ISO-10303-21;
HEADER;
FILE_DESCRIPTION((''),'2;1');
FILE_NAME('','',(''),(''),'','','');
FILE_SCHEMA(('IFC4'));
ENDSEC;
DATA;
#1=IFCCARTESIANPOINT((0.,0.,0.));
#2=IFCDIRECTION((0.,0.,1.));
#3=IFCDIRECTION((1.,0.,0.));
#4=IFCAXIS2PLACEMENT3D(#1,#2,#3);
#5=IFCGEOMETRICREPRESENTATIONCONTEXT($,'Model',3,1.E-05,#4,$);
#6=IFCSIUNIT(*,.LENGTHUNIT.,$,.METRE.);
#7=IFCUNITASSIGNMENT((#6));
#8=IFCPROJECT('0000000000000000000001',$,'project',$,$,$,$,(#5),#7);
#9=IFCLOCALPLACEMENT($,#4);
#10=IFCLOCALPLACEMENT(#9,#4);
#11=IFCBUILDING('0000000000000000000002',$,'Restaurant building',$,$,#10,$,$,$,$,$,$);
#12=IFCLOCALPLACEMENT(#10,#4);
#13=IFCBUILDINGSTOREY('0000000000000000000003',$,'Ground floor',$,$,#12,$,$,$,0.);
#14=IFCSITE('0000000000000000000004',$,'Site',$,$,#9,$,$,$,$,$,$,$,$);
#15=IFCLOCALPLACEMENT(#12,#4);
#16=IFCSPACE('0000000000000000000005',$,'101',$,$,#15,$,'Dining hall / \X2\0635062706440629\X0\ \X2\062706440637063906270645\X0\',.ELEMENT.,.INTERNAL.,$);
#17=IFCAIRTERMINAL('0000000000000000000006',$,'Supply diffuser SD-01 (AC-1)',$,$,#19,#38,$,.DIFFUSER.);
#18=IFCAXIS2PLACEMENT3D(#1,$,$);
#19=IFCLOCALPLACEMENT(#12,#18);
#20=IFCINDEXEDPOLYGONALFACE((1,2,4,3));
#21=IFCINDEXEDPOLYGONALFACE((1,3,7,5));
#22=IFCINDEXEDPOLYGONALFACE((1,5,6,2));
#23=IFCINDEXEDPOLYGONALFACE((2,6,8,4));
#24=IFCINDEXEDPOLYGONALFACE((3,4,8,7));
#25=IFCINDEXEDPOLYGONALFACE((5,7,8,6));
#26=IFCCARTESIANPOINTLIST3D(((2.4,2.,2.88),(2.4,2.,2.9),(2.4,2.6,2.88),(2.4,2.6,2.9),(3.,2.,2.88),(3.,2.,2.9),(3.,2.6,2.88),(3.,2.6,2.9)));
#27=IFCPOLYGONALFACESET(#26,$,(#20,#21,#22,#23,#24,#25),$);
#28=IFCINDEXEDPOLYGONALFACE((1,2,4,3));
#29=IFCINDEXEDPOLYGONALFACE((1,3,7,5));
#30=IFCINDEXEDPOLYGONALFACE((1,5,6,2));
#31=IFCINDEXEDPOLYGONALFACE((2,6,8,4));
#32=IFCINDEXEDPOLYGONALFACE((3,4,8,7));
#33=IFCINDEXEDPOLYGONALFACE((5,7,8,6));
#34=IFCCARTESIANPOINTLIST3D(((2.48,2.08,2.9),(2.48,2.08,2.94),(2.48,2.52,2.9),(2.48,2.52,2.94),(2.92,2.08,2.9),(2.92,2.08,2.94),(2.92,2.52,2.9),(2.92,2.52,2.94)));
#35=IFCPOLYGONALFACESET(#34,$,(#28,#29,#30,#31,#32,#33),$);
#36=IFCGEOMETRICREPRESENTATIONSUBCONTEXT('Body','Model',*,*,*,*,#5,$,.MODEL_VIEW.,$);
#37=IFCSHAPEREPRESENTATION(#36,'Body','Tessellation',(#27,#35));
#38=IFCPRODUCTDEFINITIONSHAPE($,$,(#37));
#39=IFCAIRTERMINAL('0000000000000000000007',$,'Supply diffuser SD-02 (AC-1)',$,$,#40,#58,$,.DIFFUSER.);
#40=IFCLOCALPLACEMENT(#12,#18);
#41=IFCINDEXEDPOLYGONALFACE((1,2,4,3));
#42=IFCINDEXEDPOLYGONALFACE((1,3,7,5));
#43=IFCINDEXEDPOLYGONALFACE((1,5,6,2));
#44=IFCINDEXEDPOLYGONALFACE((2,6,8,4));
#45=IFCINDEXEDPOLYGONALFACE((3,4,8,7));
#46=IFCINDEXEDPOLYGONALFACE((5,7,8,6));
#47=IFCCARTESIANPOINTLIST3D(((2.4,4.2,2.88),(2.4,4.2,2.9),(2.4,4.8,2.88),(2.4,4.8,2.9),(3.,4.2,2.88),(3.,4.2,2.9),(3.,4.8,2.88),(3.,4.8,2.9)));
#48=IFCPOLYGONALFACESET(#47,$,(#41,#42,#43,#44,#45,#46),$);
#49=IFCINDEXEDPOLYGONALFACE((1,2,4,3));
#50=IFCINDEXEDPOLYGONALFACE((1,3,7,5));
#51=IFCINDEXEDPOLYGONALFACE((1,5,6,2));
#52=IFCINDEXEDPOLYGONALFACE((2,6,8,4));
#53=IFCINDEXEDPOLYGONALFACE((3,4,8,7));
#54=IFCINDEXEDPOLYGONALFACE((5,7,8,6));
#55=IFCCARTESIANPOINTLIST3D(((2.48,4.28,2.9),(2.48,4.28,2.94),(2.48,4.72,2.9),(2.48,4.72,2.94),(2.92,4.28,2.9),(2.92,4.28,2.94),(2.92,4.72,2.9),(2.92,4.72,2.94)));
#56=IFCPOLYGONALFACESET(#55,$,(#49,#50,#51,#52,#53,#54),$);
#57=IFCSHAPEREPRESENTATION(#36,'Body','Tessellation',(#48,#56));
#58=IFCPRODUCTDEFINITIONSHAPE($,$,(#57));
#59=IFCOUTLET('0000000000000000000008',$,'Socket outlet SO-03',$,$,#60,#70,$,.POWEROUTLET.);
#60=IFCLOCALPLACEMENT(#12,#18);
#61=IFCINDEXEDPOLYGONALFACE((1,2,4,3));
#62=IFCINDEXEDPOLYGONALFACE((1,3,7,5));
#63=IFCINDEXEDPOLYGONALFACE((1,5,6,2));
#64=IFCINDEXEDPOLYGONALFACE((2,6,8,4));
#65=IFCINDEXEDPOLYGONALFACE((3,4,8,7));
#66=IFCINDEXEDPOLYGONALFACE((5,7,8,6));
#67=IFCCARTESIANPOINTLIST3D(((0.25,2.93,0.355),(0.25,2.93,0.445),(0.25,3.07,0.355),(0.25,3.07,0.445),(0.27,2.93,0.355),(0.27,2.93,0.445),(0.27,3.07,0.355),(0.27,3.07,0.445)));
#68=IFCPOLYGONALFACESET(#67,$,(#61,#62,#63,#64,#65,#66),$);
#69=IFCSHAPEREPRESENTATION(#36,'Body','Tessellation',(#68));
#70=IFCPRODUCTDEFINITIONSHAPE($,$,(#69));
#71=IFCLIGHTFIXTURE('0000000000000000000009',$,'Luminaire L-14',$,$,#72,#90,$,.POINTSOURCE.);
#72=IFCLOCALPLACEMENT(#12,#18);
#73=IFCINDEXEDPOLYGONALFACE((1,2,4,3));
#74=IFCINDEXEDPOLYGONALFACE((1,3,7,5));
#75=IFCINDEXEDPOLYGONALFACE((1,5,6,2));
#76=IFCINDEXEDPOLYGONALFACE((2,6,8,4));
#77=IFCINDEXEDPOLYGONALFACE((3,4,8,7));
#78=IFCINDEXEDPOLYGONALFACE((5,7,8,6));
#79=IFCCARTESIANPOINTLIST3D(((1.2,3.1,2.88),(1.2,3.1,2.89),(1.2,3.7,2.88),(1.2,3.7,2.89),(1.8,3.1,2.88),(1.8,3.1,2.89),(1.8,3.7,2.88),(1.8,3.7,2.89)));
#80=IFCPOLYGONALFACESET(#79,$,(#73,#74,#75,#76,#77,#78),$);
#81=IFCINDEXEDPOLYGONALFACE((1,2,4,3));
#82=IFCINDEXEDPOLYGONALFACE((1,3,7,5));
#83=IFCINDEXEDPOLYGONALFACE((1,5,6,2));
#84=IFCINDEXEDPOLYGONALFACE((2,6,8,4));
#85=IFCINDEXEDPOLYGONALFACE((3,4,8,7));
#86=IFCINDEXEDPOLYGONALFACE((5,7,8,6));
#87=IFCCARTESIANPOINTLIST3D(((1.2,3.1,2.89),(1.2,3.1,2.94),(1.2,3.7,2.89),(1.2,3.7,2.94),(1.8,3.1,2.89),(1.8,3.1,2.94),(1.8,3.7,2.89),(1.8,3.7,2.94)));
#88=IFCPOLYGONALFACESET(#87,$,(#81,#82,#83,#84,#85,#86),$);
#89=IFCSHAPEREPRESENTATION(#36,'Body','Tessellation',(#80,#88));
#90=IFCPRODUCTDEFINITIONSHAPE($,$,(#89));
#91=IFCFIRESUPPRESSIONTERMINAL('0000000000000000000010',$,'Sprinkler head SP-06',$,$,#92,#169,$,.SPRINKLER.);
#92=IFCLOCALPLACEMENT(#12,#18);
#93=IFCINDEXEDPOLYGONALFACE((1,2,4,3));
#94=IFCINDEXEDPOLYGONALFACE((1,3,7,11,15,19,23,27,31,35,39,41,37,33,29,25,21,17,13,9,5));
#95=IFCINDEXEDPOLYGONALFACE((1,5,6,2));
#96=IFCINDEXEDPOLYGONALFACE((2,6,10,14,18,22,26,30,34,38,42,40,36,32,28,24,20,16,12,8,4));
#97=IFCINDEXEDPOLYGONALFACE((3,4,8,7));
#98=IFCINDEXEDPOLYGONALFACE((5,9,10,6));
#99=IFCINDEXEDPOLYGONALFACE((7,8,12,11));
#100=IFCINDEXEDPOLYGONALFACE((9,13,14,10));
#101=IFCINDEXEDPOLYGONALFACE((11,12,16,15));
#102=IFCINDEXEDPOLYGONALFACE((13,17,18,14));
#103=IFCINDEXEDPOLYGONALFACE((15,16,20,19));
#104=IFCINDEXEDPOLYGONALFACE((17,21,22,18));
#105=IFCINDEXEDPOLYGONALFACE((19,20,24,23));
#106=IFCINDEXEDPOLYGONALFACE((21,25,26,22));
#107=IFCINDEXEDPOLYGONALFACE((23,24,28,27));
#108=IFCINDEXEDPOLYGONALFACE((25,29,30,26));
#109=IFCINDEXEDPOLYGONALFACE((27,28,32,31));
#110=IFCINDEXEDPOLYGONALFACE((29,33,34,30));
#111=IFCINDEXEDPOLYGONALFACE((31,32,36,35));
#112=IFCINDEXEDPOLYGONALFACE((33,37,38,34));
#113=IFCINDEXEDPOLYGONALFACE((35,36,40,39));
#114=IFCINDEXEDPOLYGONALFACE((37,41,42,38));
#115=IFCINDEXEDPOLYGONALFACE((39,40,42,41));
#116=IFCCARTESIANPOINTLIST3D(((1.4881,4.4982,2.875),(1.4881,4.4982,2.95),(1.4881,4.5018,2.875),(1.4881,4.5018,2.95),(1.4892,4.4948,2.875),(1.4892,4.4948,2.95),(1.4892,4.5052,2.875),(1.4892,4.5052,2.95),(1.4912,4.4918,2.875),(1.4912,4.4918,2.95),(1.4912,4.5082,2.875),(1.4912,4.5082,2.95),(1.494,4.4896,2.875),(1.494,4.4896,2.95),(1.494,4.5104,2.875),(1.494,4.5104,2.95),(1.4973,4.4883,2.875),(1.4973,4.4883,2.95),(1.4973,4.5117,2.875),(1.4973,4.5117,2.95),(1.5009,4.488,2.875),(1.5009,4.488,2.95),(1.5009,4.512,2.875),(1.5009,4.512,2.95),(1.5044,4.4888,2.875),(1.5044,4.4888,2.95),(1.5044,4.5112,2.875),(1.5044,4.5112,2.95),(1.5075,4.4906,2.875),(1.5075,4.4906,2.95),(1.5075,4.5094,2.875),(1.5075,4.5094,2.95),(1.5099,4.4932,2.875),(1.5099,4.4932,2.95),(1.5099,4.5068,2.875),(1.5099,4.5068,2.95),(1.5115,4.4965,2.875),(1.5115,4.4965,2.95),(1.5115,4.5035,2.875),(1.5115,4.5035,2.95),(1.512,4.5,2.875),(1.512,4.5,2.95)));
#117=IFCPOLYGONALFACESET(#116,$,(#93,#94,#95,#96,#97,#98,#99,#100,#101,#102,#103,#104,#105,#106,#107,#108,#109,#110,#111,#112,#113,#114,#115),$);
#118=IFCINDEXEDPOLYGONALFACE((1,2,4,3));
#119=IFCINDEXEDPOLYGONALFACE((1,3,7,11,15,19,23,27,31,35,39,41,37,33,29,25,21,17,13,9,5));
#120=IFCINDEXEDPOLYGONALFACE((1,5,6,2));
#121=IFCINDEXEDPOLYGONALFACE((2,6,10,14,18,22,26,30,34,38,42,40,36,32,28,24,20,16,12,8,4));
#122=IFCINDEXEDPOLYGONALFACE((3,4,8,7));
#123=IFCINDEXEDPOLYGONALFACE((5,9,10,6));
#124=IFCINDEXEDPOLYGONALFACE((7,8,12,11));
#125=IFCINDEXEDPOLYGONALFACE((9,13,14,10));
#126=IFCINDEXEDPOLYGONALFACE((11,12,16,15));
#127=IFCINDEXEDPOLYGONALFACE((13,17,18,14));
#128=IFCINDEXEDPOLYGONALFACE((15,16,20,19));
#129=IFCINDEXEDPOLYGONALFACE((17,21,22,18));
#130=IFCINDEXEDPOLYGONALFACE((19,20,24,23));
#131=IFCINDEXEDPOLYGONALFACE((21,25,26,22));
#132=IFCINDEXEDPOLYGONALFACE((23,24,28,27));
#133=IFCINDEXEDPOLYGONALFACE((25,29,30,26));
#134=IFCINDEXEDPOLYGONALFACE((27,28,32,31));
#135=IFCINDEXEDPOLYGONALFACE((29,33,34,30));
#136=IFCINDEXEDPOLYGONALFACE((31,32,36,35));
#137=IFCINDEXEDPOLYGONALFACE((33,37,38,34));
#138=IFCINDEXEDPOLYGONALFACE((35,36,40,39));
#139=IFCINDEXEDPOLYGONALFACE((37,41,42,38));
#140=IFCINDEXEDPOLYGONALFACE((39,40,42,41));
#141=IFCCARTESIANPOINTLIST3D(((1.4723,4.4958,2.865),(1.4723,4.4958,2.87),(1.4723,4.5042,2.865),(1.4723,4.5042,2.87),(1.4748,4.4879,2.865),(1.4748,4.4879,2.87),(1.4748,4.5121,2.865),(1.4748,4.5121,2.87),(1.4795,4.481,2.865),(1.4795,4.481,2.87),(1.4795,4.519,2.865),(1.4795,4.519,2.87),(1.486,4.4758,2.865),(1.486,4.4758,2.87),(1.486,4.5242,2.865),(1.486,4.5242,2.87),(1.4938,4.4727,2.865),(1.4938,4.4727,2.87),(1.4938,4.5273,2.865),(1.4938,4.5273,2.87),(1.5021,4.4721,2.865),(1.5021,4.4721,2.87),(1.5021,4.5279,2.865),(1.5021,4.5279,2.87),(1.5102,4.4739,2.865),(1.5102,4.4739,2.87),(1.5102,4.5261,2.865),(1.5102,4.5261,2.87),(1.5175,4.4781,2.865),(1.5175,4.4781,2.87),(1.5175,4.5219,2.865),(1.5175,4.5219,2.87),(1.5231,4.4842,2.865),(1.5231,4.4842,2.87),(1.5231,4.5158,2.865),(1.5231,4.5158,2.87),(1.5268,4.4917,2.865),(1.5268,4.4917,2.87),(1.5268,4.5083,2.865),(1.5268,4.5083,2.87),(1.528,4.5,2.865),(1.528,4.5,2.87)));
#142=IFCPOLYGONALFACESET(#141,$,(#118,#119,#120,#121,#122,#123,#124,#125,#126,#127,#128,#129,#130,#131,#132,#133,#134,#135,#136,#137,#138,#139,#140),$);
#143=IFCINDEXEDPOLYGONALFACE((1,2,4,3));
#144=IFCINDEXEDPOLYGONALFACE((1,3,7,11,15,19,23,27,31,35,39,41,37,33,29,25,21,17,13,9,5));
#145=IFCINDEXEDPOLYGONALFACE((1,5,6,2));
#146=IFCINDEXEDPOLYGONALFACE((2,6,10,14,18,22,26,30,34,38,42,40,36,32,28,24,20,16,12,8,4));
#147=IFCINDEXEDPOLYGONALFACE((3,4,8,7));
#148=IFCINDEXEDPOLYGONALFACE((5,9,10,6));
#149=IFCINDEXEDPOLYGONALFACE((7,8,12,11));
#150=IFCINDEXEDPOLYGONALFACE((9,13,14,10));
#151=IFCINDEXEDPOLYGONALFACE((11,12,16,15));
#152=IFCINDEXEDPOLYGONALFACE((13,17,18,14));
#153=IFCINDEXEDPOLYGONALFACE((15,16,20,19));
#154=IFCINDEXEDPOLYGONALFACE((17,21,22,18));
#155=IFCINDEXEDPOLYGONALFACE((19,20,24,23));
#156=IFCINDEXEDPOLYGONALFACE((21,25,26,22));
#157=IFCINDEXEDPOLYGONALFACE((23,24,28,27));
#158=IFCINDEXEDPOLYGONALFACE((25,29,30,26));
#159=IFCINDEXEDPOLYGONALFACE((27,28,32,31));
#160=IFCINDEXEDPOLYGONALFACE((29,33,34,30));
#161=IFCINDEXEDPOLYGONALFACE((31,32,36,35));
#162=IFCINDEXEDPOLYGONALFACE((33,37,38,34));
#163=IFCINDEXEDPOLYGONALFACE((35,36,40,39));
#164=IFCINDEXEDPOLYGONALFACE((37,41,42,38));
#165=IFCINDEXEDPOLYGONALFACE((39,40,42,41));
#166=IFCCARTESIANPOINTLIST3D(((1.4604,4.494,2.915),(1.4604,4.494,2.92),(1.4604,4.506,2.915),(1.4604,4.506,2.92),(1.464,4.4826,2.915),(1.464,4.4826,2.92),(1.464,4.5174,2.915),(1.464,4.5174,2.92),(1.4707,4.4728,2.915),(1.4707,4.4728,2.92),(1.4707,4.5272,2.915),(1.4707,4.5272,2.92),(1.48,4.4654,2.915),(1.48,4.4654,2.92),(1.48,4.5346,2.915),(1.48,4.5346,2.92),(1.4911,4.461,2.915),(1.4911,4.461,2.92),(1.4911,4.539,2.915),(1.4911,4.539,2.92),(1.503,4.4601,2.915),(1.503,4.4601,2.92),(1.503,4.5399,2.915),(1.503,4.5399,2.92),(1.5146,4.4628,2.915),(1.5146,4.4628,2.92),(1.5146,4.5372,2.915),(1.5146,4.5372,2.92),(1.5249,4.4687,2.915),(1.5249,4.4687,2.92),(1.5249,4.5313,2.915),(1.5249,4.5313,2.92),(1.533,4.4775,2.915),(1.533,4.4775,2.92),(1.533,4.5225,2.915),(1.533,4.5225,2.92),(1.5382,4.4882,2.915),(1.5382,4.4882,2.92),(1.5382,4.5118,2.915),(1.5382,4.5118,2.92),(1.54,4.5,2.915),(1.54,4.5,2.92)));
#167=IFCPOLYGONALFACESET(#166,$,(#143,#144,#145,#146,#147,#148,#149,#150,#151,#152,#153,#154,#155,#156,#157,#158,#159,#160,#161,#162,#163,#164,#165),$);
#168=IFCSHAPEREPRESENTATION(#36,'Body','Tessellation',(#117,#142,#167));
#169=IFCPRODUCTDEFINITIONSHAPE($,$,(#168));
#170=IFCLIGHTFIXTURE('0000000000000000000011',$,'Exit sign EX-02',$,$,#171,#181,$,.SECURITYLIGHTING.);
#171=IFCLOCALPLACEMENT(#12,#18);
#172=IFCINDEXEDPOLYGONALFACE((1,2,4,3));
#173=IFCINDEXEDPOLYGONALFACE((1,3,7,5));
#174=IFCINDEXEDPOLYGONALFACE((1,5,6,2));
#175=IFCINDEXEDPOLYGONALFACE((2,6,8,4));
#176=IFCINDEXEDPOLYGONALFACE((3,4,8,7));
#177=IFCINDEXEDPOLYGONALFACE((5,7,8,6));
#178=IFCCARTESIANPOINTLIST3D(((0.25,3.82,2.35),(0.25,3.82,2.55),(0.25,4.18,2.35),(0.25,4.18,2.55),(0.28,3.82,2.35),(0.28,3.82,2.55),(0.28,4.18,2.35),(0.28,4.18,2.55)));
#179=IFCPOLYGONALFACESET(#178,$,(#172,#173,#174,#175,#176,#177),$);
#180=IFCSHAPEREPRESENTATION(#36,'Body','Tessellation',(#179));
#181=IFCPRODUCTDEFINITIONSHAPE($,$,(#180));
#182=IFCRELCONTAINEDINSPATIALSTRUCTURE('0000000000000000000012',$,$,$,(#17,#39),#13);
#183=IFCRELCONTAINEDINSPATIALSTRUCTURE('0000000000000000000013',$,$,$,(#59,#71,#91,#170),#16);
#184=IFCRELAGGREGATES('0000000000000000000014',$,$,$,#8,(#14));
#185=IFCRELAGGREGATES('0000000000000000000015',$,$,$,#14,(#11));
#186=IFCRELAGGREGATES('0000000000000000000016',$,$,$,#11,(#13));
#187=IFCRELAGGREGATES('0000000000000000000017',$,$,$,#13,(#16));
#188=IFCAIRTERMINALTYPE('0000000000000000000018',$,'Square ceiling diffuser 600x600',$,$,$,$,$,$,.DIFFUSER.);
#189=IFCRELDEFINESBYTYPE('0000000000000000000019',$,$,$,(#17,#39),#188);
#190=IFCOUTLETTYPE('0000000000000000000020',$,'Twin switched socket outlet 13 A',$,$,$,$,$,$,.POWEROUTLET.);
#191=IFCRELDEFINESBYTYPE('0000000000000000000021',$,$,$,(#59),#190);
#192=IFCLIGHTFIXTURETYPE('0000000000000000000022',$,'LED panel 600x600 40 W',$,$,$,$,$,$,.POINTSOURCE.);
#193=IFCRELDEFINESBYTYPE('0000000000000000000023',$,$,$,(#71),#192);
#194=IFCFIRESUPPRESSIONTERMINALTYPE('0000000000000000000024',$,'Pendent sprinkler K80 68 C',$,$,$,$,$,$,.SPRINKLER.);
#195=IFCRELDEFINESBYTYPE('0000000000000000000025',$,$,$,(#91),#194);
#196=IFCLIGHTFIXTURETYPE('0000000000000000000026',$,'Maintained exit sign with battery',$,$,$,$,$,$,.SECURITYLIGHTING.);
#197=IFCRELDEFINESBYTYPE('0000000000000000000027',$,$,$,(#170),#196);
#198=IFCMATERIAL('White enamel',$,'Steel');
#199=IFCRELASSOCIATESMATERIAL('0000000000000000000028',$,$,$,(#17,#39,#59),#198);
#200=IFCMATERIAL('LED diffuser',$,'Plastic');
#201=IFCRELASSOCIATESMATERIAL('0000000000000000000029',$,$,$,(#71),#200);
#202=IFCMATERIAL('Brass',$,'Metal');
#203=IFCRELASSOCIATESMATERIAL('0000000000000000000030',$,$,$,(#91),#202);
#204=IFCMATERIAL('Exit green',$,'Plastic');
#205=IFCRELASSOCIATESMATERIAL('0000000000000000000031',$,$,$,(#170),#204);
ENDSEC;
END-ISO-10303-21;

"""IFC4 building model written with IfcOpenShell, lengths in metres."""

from ifc_helpers import new_model, si_unit, frame, origin, origin_with_axes, origin_2d, place, context, subcontext, project, spatial, rectangle, circle, extrude, source, transform, mapped, material, type_object, type_shapes, element, save


model = new_model("IFC4")

# Units and contexts
model_context = context("Model", 3, precision=1e-05, world=origin_with_axes())
body_context = subcontext(model_context, "Body", "Model", "MODEL_VIEW")
ifc_project = project(units=[si_unit("LENGTHUNIT", "METRE")], contexts=[model_context])

# Site, building, storey
site_placement = place(None, origin_with_axes())
site = spatial("IfcSite", under=ifc_project, at=site_placement, Name="Site")
building_placement = place(site_placement, origin_with_axes())
building = spatial("IfcBuilding", under=site, at=building_placement, Name="Restaurant building")
storey_placement = place(building_placement, origin_with_axes())
storey = spatial("IfcBuildingStorey", under=building, at=storey_placement, Name="Ground floor", Elevation=0.0)

# Air terminals
ifc_material_1 = material(Name="White enamel", Category="Steel")
air_terminal_type = type_object("IfcAirTerminalType", Name="Square ceiling diffuser 600x600", PredefinedType="DIFFUSER")
shared_shape_1 = source(origin(), body_context, "Body", "SweptSolid", [
    extrude(rectangle(XDim=0.6, YDim=0.6, at=origin_2d()), frame((0.0, 0.0, -0.06)), (0.0, 0.0, 1.0), 0.02),
    extrude(rectangle(XDim=0.44, YDim=0.44, at=origin_2d()), frame((0.0, 0.0, -0.04)), (0.0, 0.0, 1.0), 0.04),
])
type_shapes(air_terminal_type, [shared_shape_1])
for number, where, name in (
    (1, (2.7, 2.3, 2.94), "Supply diffuser SD-01 (AC-1)"),
    (2, (2.7, 4.5, 2.94), "Supply diffuser SD-02 (AC-1)"),
):
    element("IfcAirTerminal", number, at=place(storey_placement, frame(where)), inside=storey, type_object=air_terminal_type, material=ifc_material_1, Name=name, PredefinedType="DIFFUSER", context=body_context, shape_type="MappedRepresentation", body=[
        mapped(shared_shape_1, transform((0.0, 0.0, 0.0))),
    ])

# Shared definitions
space_placement = place(storey_placement, origin_with_axes())
space = spatial("IfcSpace", under=storey, at=space_placement, Name="101", LongName="Dining hall / صالة الطعام", CompositionType="ELEMENT", PredefinedType="INTERNAL")

# Outlet
outlet_type = type_object("IfcOutletType", Name="Twin switched socket outlet 13 A", PredefinedType="POWEROUTLET")
shared_shape_2 = source(origin(), body_context, "Body", "SweptSolid", [
    extrude(rectangle(XDim=0.14, YDim=0.02, at=origin_2d()), frame((0.0, 0.01, -0.045)), (0.0, 0.0, 1.0), 0.09),
])
type_shapes(outlet_type, [shared_shape_2])
outlet_placement = place(storey_placement, frame((0.25, 3.0, 0.4), z_axis=(0.0, 0.0, 1.0), x_axis=(0.0, -1.0, 0.0)))
element("IfcOutlet", 3, at=outlet_placement, inside=space, type_object=outlet_type, material=ifc_material_1, Name="Socket outlet SO-03", PredefinedType="POWEROUTLET", context=body_context, shape_type="MappedRepresentation", body=[
    mapped(shared_shape_2, transform((0.0, 0.0, 0.0))),
])

# Light fixture
ifc_material_2 = material(Name="LED diffuser", Category="Plastic")
light_fixture_type_1 = type_object("IfcLightFixtureType", Name="LED panel 600x600 40 W", PredefinedType="POINTSOURCE")
shared_shape_3 = source(origin(), body_context, "Body", "SweptSolid", [
    extrude(rectangle(XDim=0.6, YDim=0.6, at=origin_2d()), frame((0.0, 0.0, -0.06)), (0.0, 0.0, 1.0), 0.01),
    extrude(rectangle(XDim=0.6, YDim=0.6, at=origin_2d()), frame((0.0, 0.0, -0.05)), (0.0, 0.0, 1.0), 0.05),
])
type_shapes(light_fixture_type_1, [shared_shape_3])
light_fixture_1_placement = place(storey_placement, frame((1.5, 3.4, 2.94)))
element("IfcLightFixture", 4, at=light_fixture_1_placement, inside=space, type_object=light_fixture_type_1, material=ifc_material_2, Name="Luminaire L-14", PredefinedType="POINTSOURCE", context=body_context, shape_type="MappedRepresentation", body=[
    mapped(shared_shape_3, transform((0.0, 0.0, 0.0))),
])

# Fire suppression terminal
ifc_material_3 = material(Name="Brass", Category="Metal")
fire_suppression_terminal_type_1 = type_object("IfcFireSuppressionTerminalType", Name="Pendent sprinkler K80 68 C", PredefinedType="SPRINKLER")
shared_shape_4 = source(origin(), body_context, "Body", "SweptSolid", [
    extrude(circle(Radius=0.012, at=origin_2d()), frame((0.0, 0.0, -0.075)), (0.0, 0.0, 1.0), 0.075),
    extrude(circle(Radius=0.028, at=origin_2d()), frame((0.0, 0.0, -0.085)), (0.0, 0.0, 1.0), 0.005),
    extrude(circle(Radius=0.04, at=origin_2d()), frame((0.0, 0.0, -0.035)), (0.0, 0.0, 1.0), 0.005),
])
type_shapes(fire_suppression_terminal_type_1, [shared_shape_4])
fire_suppression_terminal_1_placement = place(storey_placement, frame((1.5, 4.5, 2.95)))
element("IfcFireSuppressionTerminal", 5, at=fire_suppression_terminal_1_placement, inside=space, type_object=fire_suppression_terminal_type_1, material=ifc_material_3, Name="Sprinkler head SP-06", PredefinedType="SPRINKLER", context=body_context, shape_type="MappedRepresentation", body=[
    mapped(shared_shape_4, transform((0.0, 0.0, 0.0))),
])

# Light fixture
ifc_material_4 = material(Name="Exit green", Category="Plastic")
light_fixture_type_2 = type_object("IfcLightFixtureType", Name="Maintained exit sign with battery", PredefinedType="SECURITYLIGHTING")
shared_shape_5 = source(origin(), body_context, "Body", "SweptSolid", [
    extrude(rectangle(XDim=0.36, YDim=0.03, at=origin_2d()), frame((0.0, 0.015, -0.1)), (0.0, 0.0, 1.0), 0.2),
])
type_shapes(light_fixture_type_2, [shared_shape_5])
light_fixture_2_placement = place(storey_placement, frame((0.25, 4.0, 2.45), z_axis=(0.0, 0.0, 1.0), x_axis=(0.0, -1.0, 0.0)))
element("IfcLightFixture", 6, at=light_fixture_2_placement, inside=space, type_object=light_fixture_type_2, material=ifc_material_4, Name="Exit sign EX-02", PredefinedType="SECURITYLIGHTING", context=body_context, shape_type="MappedRepresentation", body=[
    mapped(shared_shape_5, transform((0.0, 0.0, 0.0))),
])

save(model, "model.ifc")
